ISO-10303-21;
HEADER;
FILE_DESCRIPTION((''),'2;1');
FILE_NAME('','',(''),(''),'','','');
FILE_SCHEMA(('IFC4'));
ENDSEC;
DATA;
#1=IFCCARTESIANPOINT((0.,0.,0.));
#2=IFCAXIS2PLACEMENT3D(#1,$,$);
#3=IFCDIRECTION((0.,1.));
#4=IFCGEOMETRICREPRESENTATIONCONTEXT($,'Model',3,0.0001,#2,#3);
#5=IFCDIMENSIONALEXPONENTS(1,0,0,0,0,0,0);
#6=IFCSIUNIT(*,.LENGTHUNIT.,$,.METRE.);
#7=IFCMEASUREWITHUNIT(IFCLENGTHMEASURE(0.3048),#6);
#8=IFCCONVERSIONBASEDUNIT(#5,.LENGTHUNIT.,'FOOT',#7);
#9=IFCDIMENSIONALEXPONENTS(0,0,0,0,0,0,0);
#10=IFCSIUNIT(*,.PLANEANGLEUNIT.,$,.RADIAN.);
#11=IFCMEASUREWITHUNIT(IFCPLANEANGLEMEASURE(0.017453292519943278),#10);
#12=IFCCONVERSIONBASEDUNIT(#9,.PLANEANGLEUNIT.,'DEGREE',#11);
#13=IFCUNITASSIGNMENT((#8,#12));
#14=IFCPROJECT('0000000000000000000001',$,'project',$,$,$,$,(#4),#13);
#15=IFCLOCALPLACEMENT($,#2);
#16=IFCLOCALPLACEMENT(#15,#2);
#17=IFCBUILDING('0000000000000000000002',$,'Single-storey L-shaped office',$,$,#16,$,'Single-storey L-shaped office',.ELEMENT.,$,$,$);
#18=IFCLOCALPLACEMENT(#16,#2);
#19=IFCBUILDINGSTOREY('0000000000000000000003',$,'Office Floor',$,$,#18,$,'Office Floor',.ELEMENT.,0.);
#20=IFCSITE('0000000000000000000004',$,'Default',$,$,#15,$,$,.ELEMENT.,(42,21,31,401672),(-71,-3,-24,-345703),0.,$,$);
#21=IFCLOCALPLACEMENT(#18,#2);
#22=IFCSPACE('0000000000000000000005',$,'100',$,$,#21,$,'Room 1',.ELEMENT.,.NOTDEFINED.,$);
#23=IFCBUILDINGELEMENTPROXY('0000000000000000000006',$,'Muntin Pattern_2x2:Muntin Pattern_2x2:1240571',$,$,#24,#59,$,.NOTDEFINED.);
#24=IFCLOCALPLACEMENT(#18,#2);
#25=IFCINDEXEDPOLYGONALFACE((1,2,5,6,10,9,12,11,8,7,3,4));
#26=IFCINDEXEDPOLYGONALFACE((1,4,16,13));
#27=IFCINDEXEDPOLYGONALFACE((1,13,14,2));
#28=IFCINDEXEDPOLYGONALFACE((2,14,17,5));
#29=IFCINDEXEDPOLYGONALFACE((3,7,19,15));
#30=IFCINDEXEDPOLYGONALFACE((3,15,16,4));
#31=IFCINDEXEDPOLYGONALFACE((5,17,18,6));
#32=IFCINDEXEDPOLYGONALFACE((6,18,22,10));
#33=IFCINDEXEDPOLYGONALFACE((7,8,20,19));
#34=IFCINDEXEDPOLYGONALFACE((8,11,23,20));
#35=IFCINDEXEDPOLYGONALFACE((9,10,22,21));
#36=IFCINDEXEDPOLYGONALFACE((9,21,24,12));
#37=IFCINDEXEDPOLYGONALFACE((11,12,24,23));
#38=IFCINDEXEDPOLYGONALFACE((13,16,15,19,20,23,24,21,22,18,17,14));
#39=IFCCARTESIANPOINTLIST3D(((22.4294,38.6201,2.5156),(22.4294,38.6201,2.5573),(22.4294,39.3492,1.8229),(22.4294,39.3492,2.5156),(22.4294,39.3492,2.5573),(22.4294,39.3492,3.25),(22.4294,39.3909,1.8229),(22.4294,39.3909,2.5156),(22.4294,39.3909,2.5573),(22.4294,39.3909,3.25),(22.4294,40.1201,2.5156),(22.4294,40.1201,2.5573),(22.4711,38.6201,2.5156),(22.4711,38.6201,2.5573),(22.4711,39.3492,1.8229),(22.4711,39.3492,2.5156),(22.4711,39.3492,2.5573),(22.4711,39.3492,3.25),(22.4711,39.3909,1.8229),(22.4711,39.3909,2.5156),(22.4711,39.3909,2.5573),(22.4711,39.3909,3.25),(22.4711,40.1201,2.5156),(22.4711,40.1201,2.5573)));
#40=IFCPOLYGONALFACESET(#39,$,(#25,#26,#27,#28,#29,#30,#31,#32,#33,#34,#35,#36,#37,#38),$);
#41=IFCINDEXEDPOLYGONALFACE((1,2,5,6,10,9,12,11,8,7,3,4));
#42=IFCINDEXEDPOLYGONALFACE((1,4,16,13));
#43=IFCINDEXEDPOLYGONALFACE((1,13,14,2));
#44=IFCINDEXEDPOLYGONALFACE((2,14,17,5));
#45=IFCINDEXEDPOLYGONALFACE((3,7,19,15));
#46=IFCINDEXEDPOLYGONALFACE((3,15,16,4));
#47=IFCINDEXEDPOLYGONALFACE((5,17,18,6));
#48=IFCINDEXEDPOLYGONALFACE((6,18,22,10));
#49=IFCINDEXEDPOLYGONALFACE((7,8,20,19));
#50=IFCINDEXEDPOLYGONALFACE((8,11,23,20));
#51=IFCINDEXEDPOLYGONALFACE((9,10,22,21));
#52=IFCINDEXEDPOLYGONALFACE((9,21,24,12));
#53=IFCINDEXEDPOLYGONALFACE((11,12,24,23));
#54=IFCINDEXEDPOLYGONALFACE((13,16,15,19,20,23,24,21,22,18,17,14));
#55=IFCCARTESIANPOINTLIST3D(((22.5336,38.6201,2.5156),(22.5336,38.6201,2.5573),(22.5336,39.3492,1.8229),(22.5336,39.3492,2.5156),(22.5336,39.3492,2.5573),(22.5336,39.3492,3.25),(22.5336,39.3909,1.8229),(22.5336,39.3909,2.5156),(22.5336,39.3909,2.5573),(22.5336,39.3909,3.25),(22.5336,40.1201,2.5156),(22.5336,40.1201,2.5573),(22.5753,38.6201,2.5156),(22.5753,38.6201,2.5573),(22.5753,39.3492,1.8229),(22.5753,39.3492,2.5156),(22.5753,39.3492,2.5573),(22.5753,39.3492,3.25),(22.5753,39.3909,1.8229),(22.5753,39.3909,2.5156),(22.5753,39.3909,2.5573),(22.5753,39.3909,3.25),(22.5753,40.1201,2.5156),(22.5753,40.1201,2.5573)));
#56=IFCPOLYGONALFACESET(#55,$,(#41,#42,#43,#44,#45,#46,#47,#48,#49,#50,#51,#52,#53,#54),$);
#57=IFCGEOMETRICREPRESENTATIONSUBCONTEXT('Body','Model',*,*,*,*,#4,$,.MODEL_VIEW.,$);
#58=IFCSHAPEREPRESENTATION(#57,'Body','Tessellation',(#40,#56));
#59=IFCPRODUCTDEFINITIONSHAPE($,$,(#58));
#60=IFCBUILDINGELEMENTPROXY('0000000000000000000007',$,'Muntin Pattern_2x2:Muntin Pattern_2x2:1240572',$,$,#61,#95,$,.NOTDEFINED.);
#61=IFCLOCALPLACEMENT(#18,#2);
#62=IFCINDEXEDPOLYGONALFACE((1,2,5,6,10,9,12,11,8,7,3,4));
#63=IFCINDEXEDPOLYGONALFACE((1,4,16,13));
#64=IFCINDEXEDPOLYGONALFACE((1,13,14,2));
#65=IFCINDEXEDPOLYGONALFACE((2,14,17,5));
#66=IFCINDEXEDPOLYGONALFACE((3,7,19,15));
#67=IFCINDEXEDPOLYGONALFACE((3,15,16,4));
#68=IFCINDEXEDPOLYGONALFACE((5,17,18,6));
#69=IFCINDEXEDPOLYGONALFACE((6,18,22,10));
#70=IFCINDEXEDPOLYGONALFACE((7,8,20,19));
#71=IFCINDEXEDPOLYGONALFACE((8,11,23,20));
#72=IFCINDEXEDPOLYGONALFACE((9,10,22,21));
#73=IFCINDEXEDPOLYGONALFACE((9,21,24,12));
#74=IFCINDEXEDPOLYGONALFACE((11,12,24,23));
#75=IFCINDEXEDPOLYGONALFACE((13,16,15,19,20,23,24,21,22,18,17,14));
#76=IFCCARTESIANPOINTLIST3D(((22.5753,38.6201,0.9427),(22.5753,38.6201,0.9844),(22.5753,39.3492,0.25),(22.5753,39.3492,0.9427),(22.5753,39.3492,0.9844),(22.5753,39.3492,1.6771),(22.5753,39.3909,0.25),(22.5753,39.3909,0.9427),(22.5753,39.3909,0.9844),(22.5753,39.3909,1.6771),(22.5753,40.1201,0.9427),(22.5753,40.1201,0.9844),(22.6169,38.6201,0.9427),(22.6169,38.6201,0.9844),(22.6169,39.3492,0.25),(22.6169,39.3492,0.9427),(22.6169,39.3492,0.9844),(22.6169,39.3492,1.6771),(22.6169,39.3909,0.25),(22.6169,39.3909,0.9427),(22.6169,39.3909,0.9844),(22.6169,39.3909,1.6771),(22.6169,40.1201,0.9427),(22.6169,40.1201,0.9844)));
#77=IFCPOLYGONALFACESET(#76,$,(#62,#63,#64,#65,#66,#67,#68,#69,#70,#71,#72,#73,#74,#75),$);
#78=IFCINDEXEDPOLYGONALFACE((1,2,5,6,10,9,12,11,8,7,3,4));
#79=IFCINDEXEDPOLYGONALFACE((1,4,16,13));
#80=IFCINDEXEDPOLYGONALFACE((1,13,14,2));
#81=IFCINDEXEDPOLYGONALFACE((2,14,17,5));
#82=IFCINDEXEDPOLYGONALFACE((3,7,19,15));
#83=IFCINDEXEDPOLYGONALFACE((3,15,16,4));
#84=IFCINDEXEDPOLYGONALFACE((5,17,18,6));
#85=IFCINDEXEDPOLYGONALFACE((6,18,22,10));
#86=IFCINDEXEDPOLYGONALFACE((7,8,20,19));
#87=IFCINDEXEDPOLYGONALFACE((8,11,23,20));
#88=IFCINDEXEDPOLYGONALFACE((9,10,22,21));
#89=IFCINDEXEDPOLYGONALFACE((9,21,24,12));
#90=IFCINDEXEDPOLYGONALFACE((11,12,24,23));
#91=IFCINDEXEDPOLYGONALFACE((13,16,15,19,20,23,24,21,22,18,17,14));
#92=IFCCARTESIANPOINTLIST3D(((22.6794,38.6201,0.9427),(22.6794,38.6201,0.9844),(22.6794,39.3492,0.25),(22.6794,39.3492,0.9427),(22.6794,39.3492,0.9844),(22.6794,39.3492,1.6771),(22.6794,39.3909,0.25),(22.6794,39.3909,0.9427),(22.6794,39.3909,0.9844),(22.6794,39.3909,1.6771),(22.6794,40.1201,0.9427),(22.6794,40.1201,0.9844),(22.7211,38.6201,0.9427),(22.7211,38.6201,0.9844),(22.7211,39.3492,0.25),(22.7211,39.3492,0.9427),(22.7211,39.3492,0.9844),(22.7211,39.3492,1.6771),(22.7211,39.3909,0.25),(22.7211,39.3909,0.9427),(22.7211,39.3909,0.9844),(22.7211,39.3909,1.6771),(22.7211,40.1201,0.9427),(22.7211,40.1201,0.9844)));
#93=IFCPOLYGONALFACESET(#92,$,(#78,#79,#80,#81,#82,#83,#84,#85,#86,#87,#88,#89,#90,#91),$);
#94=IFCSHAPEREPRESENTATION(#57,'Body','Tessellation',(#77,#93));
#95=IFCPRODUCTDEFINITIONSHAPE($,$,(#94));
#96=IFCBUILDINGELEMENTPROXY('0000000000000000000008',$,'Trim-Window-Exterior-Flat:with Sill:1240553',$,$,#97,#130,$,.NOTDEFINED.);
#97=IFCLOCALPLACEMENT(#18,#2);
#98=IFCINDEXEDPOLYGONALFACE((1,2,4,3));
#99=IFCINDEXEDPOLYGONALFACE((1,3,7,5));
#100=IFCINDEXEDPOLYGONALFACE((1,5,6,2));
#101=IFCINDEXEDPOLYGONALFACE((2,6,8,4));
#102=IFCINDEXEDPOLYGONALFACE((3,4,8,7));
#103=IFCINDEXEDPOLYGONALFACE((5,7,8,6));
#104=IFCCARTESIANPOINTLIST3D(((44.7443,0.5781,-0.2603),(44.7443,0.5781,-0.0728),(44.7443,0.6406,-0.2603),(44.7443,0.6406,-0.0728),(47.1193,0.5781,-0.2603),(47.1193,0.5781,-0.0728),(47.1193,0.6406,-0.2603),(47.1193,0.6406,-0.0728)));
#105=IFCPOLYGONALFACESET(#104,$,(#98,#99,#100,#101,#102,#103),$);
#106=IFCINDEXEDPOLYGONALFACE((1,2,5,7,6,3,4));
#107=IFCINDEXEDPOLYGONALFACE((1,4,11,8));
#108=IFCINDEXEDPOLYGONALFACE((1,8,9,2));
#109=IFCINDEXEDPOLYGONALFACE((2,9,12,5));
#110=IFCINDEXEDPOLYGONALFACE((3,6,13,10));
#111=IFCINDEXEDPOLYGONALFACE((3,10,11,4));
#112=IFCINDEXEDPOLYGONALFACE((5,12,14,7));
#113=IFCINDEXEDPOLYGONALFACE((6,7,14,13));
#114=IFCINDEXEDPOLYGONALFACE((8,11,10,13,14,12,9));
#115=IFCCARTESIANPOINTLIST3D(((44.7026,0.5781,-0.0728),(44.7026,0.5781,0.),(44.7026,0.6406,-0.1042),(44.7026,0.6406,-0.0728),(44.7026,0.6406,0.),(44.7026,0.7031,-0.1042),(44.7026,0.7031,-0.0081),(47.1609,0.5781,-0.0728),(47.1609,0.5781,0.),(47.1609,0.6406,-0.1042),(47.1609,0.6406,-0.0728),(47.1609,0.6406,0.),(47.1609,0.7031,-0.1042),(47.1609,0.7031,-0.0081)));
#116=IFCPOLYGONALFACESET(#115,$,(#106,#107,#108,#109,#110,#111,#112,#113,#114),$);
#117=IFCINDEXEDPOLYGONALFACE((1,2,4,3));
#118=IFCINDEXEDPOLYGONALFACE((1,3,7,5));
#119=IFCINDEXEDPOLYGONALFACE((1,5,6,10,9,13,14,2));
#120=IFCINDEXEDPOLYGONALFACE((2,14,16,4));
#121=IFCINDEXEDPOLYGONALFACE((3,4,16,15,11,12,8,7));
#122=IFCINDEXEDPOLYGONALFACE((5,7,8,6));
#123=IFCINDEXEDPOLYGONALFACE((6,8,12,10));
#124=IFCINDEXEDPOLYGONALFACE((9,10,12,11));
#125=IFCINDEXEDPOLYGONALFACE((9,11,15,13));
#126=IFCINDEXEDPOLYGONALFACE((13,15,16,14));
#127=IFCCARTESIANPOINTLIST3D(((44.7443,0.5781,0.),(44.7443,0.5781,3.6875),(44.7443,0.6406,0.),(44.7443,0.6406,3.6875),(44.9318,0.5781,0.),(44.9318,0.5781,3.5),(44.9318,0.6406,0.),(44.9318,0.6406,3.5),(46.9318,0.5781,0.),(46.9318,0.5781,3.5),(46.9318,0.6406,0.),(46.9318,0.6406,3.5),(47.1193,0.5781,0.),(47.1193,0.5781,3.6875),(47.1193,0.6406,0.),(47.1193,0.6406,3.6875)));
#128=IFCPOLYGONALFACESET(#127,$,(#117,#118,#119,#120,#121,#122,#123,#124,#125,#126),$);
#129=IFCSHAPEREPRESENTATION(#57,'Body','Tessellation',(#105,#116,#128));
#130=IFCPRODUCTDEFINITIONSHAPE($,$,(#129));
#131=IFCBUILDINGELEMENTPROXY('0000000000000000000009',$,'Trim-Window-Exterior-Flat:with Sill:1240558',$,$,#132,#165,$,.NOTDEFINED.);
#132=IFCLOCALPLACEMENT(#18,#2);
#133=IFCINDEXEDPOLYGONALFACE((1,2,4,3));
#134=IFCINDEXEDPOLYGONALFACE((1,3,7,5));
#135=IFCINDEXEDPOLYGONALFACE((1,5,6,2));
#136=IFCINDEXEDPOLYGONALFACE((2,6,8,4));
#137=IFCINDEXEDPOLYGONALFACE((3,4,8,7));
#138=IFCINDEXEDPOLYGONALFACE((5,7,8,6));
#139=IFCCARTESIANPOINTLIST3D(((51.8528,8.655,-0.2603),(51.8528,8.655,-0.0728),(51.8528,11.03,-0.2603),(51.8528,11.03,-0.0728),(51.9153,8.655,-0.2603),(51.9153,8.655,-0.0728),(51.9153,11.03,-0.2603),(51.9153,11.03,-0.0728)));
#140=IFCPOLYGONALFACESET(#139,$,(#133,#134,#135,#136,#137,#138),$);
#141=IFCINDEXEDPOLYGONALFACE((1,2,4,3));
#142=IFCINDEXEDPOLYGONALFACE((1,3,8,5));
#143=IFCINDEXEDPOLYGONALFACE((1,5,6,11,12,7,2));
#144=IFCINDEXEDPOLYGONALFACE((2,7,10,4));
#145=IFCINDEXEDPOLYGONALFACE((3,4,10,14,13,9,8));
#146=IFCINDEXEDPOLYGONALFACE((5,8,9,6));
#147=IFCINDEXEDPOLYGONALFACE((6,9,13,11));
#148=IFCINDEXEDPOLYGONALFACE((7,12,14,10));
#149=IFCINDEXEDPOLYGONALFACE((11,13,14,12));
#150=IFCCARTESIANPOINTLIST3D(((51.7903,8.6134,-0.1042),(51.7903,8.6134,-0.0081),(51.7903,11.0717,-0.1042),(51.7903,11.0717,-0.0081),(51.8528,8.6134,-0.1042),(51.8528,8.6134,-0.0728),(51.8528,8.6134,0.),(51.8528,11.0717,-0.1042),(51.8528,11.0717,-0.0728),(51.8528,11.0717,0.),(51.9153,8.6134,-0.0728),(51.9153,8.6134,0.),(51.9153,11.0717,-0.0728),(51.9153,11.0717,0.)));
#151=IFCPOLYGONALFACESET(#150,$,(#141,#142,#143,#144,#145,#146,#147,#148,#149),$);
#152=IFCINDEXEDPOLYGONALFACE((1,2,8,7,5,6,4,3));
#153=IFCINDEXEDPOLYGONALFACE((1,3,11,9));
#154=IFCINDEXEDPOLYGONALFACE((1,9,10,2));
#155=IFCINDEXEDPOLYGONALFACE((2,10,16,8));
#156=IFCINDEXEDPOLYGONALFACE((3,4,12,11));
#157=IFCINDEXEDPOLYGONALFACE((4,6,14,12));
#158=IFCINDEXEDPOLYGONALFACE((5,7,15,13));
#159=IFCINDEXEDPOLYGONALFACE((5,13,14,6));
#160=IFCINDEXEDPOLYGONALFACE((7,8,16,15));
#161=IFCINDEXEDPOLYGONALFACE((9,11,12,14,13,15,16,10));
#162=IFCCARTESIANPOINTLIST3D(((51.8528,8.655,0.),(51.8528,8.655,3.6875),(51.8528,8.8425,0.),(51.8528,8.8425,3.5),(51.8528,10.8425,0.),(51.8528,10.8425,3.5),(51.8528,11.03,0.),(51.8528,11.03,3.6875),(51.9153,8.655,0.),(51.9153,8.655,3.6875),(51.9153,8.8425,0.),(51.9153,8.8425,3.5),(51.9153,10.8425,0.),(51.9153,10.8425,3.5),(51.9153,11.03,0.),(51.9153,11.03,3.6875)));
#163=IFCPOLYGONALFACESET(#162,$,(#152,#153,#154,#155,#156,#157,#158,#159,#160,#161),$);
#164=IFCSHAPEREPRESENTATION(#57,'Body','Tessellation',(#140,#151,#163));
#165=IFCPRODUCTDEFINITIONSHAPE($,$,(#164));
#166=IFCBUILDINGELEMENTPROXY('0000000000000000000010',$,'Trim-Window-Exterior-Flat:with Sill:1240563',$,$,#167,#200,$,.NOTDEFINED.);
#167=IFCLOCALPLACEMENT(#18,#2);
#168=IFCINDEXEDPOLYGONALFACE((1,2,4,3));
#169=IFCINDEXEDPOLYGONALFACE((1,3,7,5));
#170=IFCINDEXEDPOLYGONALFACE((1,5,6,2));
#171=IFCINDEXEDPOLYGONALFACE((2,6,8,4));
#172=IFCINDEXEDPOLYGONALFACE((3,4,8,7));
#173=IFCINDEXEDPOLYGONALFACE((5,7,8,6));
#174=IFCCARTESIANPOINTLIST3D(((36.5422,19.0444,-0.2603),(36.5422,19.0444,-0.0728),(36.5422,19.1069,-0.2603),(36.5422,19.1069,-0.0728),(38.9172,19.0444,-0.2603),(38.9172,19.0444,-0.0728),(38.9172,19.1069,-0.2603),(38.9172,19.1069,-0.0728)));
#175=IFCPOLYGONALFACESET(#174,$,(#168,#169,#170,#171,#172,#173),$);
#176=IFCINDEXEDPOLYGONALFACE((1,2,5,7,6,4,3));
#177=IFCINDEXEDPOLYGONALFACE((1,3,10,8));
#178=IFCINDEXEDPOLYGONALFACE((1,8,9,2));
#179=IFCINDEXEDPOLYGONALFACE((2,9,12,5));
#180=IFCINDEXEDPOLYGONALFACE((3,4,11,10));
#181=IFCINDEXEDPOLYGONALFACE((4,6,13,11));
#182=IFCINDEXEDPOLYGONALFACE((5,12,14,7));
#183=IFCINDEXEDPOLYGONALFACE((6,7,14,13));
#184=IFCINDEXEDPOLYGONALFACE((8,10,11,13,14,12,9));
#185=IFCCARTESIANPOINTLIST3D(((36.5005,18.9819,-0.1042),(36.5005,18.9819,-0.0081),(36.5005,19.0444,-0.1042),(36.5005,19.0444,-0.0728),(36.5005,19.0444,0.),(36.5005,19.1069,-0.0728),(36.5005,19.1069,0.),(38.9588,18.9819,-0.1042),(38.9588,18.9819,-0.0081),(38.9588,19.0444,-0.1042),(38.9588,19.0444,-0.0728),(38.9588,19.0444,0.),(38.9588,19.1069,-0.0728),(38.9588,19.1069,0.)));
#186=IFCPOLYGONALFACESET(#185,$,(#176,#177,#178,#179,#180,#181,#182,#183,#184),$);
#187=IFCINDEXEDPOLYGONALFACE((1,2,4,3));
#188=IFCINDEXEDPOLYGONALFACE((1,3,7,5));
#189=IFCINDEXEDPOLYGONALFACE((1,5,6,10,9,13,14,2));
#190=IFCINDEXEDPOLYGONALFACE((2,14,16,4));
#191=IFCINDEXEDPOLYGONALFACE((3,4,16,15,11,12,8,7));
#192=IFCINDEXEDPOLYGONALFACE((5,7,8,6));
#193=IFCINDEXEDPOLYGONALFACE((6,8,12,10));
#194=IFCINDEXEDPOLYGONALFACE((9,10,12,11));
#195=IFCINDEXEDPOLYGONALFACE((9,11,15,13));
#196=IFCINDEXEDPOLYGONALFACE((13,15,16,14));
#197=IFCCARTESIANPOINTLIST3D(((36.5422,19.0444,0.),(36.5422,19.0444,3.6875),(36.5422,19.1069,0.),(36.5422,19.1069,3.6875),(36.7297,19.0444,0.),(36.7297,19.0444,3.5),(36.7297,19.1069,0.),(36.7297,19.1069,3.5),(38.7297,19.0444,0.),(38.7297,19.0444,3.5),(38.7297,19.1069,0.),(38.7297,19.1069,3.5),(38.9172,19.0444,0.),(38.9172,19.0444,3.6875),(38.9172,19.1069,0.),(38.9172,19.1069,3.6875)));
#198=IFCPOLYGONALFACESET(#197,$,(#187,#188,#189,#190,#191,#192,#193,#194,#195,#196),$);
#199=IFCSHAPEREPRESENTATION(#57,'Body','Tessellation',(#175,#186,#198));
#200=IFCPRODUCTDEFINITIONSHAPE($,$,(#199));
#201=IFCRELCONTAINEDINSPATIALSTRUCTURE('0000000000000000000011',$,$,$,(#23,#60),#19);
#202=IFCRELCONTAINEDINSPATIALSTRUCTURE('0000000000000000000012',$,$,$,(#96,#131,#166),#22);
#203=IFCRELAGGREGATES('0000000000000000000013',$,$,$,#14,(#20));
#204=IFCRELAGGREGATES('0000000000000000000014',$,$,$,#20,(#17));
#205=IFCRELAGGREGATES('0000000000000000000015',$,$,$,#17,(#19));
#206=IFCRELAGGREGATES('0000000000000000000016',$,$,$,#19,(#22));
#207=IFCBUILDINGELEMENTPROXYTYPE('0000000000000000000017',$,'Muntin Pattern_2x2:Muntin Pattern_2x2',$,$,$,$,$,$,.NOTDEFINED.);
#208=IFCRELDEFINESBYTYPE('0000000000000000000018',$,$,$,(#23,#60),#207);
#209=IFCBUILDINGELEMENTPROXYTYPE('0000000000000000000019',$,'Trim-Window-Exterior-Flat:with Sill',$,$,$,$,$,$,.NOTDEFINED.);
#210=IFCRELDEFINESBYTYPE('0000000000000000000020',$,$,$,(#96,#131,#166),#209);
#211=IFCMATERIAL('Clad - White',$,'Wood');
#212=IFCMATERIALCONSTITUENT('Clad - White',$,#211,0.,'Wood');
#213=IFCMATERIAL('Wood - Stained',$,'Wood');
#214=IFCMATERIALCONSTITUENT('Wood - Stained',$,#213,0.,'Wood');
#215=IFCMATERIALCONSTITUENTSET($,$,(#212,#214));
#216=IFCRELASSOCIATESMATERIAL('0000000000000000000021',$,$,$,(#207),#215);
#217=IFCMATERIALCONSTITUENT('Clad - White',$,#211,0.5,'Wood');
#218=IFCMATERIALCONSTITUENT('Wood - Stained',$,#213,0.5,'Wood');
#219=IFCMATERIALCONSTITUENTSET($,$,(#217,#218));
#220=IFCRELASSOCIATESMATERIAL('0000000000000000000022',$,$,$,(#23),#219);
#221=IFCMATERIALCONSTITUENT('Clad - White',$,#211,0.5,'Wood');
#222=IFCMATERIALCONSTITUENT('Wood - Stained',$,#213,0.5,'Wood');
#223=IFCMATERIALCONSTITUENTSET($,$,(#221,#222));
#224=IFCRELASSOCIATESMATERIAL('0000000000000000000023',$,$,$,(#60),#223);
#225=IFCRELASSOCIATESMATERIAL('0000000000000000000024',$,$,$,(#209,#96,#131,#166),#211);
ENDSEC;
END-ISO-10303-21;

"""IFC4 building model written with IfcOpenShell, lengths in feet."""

from ifc_helpers import new_model, entity, si_unit, converted_unit, direction, frame, origin, place, context, subcontext, project, spatial, indexed_curve, outline, extrude, source, transform, mapped, material, constituent, constituent_set, type_object, type_shapes, element, save


model = new_model("IFC4")

# Units and contexts
model_context = context("Model", 3, precision=0.0001, world=origin(), true_north=direction((0.0, 1.0)))
body_context = subcontext(model_context, "Body", "Model", "MODEL_VIEW")
ifc_project = project(units=[converted_unit("LENGTHUNIT", "FOOT", entity("IfcLengthMeasure", 0.3048), si_unit("LENGTHUNIT", "METRE"), dimensions=[1, 0, 0, 0, 0, 0, 0]), converted_unit("PLANEANGLEUNIT", "DEGREE", entity("IfcPlaneAngleMeasure", 0.017453292519943278), si_unit("PLANEANGLEUNIT", "RADIAN"), dimensions=[0, 0, 0, 0, 0, 0, 0])], contexts=[model_context])

# Site, building, storey
site_placement = place(None, origin())
site = spatial("IfcSite", under=ifc_project, at=site_placement, Name="Default", CompositionType="ELEMENT", RefLatitude=(42, 21, 31, 401672), RefLongitude=(-71, -3, -24, -345703), RefElevation=0.0)
building_placement = place(site_placement, origin())
building = spatial("IfcBuilding", under=site, at=building_placement, Name="Single-storey L-shaped office", LongName="Single-storey L-shaped office", CompositionType="ELEMENT")
storey_placement = place(building_placement, origin())
storey = spatial("IfcBuildingStorey", under=building, at=storey_placement, Name="Office Floor", LongName="Office Floor", CompositionType="ELEMENT", Elevation=0.0)

# Shared definitions
ifc_material_1 = material(Name="Wood - Stained", Category="Wood")

# Building element proxies
ifc_material_2 = material(Name="Clad - White", Category="Wood")
ifc_constituent_1 = constituent(ifc_material_2, Name="Clad - White", Category="Wood", fraction=0.0)
ifc_constituent_2 = constituent(ifc_material_1, Name="Wood - Stained", Category="Wood", fraction=0.0)
ifc_constituent_set_1 = constituent_set(constituents=[ifc_constituent_1, ifc_constituent_2])
building_element_proxy_type_1 = type_object("IfcBuildingElementProxyType", Name="Muntin Pattern_2x2:Muntin Pattern_2x2", PredefinedType="NOTDEFINED", material=ifc_constituent_set_1)
shared_shape_1 = source(origin(), body_context, "Body", "SweptSolid", [
    extrude(outline(indexed_curve([(0.0208, -0.0208), (0.7135, -0.0208), (0.7135, 0.0208), (0.0208, 0.0208), (0.0208, 0.75), (-0.0208, 0.75), (-0.0208, 0.0208), (-0.7135, 0.0208), (-0.7135, -0.0208), (-0.0208, -0.0208), (-0.0208, -0.75), (0.0208, -0.75), (0.0208, -0.0208)], self_intersect=False)), frame((0.0, 0.0312, 0.7135), z_axis=(0.0, 1.0, 0.0), x_axis=(0.0, 0.0, 1.0)), (0.0, 0.0, 1.0), 0.0417),
    extrude(outline(indexed_curve([(0.0208, -0.0208), (0.7135, -0.0208), (0.7135, 0.0208), (0.0208, 0.0208), (0.0208, 0.75), (-0.0208, 0.75), (-0.0208, 0.0208), (-0.7135, 0.0208), (-0.7135, -0.0208), (-0.0208, -0.0208), (-0.0208, -0.75), (0.0208, -0.75), (0.0208, -0.0208)], self_intersect=False)), frame((0.0, -0.0729, 0.7135), z_axis=(0.0, 1.0, 0.0), x_axis=(0.0, 0.0, 1.0)), (0.0, 0.0, 1.0), 0.0417),
])
type_shapes(building_element_proxy_type_1, [shared_shape_1])
ifc_constituent_3 = constituent(ifc_material_2, Name="Clad - White", Category="Wood", fraction=0.5)
ifc_constituent_4 = constituent(ifc_material_1, Name="Wood - Stained", Category="Wood", fraction=0.5)
ifc_constituent_set_2 = constituent_set(constituents=[ifc_constituent_3, ifc_constituent_4])
proxy_1_placement = place(storey_placement, frame((22.5023, 39.3701, 1.8229), z_axis=(0.0, 0.0, 1.0), x_axis=(0.0, 1.0, 0.0)))
element("IfcBuildingElementProxy", 1, at=proxy_1_placement, inside=storey, type_object=building_element_proxy_type_1, material=ifc_constituent_set_2, Name="Muntin Pattern_2x2:Muntin Pattern_2x2:1240571", PredefinedType="NOTDEFINED", context=body_context, shape_type="MappedRepresentation", body=[
    mapped(shared_shape_1, transform((0.0, 0.0, 0.0), scale=1.0)),
])
ifc_constituent_5 = constituent(ifc_material_2, Name="Clad - White", Category="Wood", fraction=0.5)
ifc_constituent_6 = constituent(ifc_material_1, Name="Wood - Stained", Category="Wood", fraction=0.5)
ifc_constituent_set_3 = constituent_set(constituents=[ifc_constituent_5, ifc_constituent_6])
proxy_2_placement = place(storey_placement, frame((22.6482, 39.3701, 0.25), z_axis=(0.0, 0.0, 1.0), x_axis=(0.0, 1.0, 0.0)))
element("IfcBuildingElementProxy", 2, at=proxy_2_placement, inside=storey, type_object=building_element_proxy_type_1, material=ifc_constituent_set_3, Name="Muntin Pattern_2x2:Muntin Pattern_2x2:1240572", PredefinedType="NOTDEFINED", context=body_context, shape_type="MappedRepresentation", body=[
    mapped(shared_shape_1, transform((0.0, 0.0, 0.0), scale=1.0)),
])

# Shared definitions
space_1_placement = place(storey_placement, origin())
space_1 = spatial("IfcSpace", under=storey, at=space_1_placement, Name="100", LongName="Room 1", CompositionType="ELEMENT", PredefinedType="NOTDEFINED")

# Building element proxies
building_element_proxy_type_2 = type_object("IfcBuildingElementProxyType", Name="Trim-Window-Exterior-Flat:with Sill", PredefinedType="NOTDEFINED", material=ifc_material_2)
shared_shape_2 = source(origin(), body_context, "Body", "SweptSolid", [
    extrude(outline(indexed_curve([(-1.1875, -0.0938), (1.1875, -0.0938), (1.1875, 0.0938), (-1.1875, 0.0938), (-1.1875, -0.0938)], self_intersect=False)), frame((0.0, -3.6665, 0.0), z_axis=(0.0, 0.0, 1.0), x_axis=(-1.0, 0.0, 0.0)), (0.0, 0.0, 1.0), 0.0625),
    extrude(outline(indexed_curve([(-0.0625, -0.0525), (0.0, -0.0525), (0.0, -0.0211), (0.0625, -0.0211), (0.0625, 0.0517), (0.0, 0.0517), (-0.0625, 0.0436), (-0.0625, -0.0525)], self_intersect=False)), frame((-1.2292, -3.5517, 0.0625), z_axis=(1.0, 0.0, 0.0), x_axis=(0.0, 0.0, -1.0)), (0.0, 0.0, 1.0), 2.4583),
    extrude(outline(indexed_curve([(-1.8906, -1.1875), (1.7969, -1.1875), (1.7969, -1.0), (-1.7031, -1.0), (-1.7031, 1.0), (1.7969, 1.0), (1.7969, 1.1875), (-1.8906, 1.1875), (-1.8906, -1.1875)], self_intersect=False)), frame((0.0, -1.7031, 0.0), z_axis=(0.0, 0.0, 1.0), x_axis=(0.0, -1.0, 0.0)), (0.0, 0.0, 1.0), 0.0625),
])
type_shapes(building_element_proxy_type_2, [shared_shape_2])
for number, where, z_axis, x_axis, name in (
    (3, (45.9318, 0.5781, 3.5), (0.0, 1.0, 0.0), (-1.0, 0.0, 0.0), "Trim-Window-Exterior-Flat:with Sill:1240553"),
    (4, (51.9153, 9.8425, 3.5), (-1.0, 0.0, 0.0), (0.0, -1.0, 0.0), "Trim-Window-Exterior-Flat:with Sill:1240558"),
    (5, (37.7297, 19.1069, 3.5), (0.0, -1.0, 0.0), (1.0, 0.0, 0.0), "Trim-Window-Exterior-Flat:with Sill:1240563"),
):
    element("IfcBuildingElementProxy", number, at=place(space_1_placement, frame(where, z_axis=z_axis, x_axis=x_axis)), inside=space_1, type_object=building_element_proxy_type_2, material=ifc_material_2, Name=name, PredefinedType="NOTDEFINED", context=body_context, shape_type="MappedRepresentation", body=[
        mapped(shared_shape_2, transform((0.0, 0.0, 0.0), scale=1.0)),
    ])

save(model, "model.ifc")
